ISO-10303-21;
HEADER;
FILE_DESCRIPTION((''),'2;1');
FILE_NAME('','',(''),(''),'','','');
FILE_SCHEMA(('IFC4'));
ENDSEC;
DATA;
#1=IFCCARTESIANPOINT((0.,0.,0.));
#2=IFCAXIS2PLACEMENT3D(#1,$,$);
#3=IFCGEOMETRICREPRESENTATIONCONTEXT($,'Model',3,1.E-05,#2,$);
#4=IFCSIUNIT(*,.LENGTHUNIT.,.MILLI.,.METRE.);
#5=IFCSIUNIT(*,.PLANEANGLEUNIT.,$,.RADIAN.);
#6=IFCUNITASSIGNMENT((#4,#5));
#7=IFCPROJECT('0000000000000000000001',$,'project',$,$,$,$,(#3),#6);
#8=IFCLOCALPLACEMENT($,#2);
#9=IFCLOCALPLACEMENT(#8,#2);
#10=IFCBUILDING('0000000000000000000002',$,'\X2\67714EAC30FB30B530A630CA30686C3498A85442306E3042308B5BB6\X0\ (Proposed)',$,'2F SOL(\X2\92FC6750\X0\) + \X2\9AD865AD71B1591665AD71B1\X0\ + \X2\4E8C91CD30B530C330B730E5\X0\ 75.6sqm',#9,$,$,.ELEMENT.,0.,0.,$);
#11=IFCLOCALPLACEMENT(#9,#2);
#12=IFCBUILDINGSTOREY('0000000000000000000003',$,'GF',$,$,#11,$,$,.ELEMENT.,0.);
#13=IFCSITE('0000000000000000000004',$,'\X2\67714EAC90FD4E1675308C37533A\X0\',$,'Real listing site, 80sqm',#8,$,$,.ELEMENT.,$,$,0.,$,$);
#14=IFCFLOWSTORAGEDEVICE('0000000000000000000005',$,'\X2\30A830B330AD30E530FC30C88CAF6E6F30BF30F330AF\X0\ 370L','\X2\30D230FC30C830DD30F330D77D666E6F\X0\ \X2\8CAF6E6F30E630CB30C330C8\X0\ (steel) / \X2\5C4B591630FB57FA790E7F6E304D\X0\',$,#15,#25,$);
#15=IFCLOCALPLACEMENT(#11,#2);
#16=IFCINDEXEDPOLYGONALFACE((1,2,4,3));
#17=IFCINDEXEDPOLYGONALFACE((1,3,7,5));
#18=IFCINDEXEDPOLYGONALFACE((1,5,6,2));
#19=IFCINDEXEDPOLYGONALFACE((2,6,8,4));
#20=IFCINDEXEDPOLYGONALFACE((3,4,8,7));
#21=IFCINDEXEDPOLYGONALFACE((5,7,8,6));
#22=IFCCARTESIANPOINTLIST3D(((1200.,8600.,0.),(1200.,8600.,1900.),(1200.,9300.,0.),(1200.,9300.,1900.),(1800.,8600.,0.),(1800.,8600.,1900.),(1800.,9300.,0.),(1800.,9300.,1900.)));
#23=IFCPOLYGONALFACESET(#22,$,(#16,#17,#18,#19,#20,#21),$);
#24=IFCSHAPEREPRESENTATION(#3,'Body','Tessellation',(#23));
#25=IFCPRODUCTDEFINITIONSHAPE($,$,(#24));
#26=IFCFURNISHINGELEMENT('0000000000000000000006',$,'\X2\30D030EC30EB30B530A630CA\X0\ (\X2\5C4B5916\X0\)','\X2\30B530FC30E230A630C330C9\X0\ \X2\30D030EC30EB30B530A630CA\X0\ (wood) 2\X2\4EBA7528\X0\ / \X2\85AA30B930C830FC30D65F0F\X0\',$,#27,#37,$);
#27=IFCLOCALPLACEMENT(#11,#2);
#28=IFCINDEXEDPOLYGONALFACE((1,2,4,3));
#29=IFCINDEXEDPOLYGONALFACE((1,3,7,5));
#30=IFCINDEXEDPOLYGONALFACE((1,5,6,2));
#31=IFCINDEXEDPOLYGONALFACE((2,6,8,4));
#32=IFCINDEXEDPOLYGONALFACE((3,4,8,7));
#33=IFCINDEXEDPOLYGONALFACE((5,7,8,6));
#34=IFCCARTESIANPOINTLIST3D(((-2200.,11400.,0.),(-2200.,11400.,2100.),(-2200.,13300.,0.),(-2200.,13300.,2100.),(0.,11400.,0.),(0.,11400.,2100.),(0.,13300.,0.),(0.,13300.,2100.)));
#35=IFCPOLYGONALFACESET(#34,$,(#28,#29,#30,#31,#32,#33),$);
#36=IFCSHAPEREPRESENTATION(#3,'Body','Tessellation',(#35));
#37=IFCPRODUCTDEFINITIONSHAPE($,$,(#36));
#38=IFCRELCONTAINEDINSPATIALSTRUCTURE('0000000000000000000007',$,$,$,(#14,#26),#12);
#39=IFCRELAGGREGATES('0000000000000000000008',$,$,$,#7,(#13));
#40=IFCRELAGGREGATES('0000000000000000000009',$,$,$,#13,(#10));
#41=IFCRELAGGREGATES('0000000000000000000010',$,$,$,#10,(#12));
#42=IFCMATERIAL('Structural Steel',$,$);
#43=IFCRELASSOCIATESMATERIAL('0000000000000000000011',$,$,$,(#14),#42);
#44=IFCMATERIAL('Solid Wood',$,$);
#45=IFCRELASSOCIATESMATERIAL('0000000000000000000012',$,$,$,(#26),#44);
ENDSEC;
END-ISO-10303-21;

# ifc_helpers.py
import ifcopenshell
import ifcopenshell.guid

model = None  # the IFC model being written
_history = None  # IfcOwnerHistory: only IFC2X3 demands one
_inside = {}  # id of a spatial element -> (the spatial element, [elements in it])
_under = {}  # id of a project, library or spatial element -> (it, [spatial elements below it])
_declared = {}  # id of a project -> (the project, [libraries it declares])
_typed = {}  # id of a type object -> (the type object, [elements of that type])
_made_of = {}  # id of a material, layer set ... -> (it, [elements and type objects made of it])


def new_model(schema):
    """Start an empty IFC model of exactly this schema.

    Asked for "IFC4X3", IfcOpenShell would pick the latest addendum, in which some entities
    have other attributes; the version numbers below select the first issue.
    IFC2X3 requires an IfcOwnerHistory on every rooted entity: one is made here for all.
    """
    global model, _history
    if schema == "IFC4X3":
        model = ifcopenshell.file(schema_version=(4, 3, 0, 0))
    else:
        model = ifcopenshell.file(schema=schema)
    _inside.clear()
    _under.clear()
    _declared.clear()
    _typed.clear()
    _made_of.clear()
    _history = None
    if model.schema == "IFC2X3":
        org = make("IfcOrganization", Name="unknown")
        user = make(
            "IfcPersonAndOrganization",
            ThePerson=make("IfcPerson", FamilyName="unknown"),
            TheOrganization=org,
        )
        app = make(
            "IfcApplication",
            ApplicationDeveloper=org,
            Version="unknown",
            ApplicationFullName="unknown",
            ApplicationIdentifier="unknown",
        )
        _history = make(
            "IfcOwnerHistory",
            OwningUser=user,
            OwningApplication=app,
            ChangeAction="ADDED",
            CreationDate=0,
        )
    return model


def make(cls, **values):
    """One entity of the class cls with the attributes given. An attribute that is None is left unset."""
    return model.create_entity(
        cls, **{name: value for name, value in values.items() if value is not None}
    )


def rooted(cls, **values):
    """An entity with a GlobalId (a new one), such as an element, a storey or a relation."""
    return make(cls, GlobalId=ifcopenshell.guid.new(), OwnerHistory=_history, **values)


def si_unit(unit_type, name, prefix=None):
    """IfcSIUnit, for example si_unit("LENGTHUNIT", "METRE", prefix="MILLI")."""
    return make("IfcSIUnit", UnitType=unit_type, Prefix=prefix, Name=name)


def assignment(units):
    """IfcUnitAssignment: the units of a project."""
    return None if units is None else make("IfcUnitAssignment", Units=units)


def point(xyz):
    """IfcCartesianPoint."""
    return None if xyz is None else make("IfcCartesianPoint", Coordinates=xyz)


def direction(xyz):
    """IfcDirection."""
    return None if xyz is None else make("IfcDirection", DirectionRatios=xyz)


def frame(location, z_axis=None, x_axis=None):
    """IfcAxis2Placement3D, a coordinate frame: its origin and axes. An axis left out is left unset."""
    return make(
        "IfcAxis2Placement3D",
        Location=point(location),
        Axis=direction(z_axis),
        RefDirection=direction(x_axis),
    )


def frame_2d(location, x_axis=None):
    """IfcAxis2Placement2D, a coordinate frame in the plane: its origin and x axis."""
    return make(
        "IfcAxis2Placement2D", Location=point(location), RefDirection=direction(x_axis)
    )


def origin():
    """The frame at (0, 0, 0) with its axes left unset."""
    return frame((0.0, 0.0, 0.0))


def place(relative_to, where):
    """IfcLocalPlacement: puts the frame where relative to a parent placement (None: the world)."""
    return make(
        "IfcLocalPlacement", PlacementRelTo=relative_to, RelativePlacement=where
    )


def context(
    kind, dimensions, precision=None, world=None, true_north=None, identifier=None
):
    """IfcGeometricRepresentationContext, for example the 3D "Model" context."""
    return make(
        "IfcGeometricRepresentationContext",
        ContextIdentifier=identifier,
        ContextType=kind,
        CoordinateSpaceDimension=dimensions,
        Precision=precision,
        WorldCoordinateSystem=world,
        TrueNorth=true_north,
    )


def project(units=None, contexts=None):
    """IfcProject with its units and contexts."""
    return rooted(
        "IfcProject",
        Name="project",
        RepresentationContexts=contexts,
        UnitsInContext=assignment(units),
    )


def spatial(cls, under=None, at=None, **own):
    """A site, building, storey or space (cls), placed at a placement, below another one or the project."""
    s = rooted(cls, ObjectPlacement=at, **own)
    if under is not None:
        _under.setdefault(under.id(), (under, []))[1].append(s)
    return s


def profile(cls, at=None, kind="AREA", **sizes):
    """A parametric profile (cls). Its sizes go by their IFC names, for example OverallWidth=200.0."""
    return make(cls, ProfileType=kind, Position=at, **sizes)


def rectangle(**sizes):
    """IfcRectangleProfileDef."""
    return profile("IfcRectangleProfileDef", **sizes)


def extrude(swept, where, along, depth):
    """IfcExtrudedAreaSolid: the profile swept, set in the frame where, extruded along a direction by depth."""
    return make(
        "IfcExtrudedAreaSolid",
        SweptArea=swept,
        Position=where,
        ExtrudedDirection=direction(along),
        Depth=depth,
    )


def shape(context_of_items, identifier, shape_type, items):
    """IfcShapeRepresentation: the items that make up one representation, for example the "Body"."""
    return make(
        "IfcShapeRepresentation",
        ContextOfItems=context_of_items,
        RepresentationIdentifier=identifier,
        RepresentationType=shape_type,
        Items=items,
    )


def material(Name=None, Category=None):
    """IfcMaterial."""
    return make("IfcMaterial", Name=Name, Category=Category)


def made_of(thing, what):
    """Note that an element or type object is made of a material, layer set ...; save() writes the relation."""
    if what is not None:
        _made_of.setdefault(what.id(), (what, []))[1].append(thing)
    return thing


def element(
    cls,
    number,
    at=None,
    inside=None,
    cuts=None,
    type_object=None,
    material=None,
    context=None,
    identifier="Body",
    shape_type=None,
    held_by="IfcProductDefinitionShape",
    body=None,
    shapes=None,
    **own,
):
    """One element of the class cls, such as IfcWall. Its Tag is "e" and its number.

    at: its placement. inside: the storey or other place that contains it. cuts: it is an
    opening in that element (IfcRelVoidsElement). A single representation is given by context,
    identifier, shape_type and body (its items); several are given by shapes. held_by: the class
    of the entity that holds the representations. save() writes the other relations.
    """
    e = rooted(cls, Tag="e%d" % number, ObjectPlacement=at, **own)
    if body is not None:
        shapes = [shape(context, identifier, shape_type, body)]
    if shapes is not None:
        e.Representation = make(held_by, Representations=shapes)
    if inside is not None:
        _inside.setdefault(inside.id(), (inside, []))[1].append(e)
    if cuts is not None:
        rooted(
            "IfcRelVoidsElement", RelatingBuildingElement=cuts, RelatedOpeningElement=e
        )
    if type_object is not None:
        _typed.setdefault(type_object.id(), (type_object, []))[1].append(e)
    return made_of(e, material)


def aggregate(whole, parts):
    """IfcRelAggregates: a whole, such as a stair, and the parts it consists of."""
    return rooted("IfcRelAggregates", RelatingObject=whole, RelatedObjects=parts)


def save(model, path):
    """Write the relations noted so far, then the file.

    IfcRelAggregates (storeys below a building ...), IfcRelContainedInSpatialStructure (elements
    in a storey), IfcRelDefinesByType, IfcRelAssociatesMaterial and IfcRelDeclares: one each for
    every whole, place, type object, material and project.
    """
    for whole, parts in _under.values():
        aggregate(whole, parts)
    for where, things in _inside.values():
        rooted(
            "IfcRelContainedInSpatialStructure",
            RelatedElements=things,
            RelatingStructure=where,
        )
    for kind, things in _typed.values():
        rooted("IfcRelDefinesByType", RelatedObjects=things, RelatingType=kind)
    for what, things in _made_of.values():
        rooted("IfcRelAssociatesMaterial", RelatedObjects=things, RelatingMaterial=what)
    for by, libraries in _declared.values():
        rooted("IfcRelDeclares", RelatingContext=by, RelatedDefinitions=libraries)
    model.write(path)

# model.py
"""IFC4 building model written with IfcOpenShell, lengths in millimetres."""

from ifc_helpers import new_model, si_unit, frame, frame_2d, origin, place, context, project, spatial, rectangle, extrude, material, element, save


model = new_model("IFC4")

# Units and contexts
model_context = context("Model", 3, precision=1e-05, world=origin())
ifc_project = project(units=[si_unit("LENGTHUNIT", "METRE", prefix="MILLI"), si_unit("PLANEANGLEUNIT", "RADIAN")], contexts=[model_context])

# Site, building, storey
site_placement = place(None, origin())
site = spatial("IfcSite", under=ifc_project, at=site_placement, Name="東京都世田谷区", ObjectType="Real listing site, 80sqm", CompositionType="ELEMENT", RefElevation=0.0)
building_placement = place(site_placement, origin())
building = spatial("IfcBuilding", under=site, at=building_placement, Name="東京・サウナと水風呂のある家 (Proposed)", ObjectType="2F SOL(鋼材) + 高断熱外断熱 + 二重サッシュ 75.6sqm", CompositionType="ELEMENT", ElevationOfRefHeight=0.0, ElevationOfTerrain=0.0)
storey_placement = place(building_placement, origin())
storey = spatial("IfcBuildingStorey", under=building, at=storey_placement, Name="GF", CompositionType="ELEMENT", Elevation=0.0)

# Shared definitions
ifc_material_1 = material(Name="Solid Wood")

# Flow storage device
ifc_material_2 = material(Name="Structural Steel")
flow_storage_device_placement = place(storey_placement, frame((600.0, 4300.0, 0.0)))
element("IfcFlowStorageDevice", 1, at=flow_storage_device_placement, inside=storey, material=ifc_material_2, Name="エコキュート貯湯タンク 370L", Description="ヒートポンプ給湯 貯湯ユニット (steel) / 屋外・基礎置き", context=model_context, shape_type="SweptSolid", body=[
    extrude(rectangle(XDim=600.0, YDim=700.0, at=frame_2d((300.0, 350.0))), frame((600.0, 4300.0, 0.0)), (0.0, 0.0, 1.0), 1900.0),
])

# Furnishing element
furnishing_1_placement = place(storey_placement, frame((-1100.0, 5700.0, 0.0)))
element("IfcFurnishingElement", 2, at=furnishing_1_placement, inside=storey, material=ifc_material_1, Name="バレルサウナ (屋外)", Description="サーモウッド バレルサウナ (wood) 2人用 / 薪ストーブ式", context=model_context, shape_type="SweptSolid", body=[
    extrude(rectangle(XDim=2200.0, YDim=1900.0, at=frame_2d((1100.0, 950.0))), frame((-1100.0, 5700.0, 0.0)), (0.0, 0.0, 1.0), 2100.0),
])

save(model, "model.ifc")
